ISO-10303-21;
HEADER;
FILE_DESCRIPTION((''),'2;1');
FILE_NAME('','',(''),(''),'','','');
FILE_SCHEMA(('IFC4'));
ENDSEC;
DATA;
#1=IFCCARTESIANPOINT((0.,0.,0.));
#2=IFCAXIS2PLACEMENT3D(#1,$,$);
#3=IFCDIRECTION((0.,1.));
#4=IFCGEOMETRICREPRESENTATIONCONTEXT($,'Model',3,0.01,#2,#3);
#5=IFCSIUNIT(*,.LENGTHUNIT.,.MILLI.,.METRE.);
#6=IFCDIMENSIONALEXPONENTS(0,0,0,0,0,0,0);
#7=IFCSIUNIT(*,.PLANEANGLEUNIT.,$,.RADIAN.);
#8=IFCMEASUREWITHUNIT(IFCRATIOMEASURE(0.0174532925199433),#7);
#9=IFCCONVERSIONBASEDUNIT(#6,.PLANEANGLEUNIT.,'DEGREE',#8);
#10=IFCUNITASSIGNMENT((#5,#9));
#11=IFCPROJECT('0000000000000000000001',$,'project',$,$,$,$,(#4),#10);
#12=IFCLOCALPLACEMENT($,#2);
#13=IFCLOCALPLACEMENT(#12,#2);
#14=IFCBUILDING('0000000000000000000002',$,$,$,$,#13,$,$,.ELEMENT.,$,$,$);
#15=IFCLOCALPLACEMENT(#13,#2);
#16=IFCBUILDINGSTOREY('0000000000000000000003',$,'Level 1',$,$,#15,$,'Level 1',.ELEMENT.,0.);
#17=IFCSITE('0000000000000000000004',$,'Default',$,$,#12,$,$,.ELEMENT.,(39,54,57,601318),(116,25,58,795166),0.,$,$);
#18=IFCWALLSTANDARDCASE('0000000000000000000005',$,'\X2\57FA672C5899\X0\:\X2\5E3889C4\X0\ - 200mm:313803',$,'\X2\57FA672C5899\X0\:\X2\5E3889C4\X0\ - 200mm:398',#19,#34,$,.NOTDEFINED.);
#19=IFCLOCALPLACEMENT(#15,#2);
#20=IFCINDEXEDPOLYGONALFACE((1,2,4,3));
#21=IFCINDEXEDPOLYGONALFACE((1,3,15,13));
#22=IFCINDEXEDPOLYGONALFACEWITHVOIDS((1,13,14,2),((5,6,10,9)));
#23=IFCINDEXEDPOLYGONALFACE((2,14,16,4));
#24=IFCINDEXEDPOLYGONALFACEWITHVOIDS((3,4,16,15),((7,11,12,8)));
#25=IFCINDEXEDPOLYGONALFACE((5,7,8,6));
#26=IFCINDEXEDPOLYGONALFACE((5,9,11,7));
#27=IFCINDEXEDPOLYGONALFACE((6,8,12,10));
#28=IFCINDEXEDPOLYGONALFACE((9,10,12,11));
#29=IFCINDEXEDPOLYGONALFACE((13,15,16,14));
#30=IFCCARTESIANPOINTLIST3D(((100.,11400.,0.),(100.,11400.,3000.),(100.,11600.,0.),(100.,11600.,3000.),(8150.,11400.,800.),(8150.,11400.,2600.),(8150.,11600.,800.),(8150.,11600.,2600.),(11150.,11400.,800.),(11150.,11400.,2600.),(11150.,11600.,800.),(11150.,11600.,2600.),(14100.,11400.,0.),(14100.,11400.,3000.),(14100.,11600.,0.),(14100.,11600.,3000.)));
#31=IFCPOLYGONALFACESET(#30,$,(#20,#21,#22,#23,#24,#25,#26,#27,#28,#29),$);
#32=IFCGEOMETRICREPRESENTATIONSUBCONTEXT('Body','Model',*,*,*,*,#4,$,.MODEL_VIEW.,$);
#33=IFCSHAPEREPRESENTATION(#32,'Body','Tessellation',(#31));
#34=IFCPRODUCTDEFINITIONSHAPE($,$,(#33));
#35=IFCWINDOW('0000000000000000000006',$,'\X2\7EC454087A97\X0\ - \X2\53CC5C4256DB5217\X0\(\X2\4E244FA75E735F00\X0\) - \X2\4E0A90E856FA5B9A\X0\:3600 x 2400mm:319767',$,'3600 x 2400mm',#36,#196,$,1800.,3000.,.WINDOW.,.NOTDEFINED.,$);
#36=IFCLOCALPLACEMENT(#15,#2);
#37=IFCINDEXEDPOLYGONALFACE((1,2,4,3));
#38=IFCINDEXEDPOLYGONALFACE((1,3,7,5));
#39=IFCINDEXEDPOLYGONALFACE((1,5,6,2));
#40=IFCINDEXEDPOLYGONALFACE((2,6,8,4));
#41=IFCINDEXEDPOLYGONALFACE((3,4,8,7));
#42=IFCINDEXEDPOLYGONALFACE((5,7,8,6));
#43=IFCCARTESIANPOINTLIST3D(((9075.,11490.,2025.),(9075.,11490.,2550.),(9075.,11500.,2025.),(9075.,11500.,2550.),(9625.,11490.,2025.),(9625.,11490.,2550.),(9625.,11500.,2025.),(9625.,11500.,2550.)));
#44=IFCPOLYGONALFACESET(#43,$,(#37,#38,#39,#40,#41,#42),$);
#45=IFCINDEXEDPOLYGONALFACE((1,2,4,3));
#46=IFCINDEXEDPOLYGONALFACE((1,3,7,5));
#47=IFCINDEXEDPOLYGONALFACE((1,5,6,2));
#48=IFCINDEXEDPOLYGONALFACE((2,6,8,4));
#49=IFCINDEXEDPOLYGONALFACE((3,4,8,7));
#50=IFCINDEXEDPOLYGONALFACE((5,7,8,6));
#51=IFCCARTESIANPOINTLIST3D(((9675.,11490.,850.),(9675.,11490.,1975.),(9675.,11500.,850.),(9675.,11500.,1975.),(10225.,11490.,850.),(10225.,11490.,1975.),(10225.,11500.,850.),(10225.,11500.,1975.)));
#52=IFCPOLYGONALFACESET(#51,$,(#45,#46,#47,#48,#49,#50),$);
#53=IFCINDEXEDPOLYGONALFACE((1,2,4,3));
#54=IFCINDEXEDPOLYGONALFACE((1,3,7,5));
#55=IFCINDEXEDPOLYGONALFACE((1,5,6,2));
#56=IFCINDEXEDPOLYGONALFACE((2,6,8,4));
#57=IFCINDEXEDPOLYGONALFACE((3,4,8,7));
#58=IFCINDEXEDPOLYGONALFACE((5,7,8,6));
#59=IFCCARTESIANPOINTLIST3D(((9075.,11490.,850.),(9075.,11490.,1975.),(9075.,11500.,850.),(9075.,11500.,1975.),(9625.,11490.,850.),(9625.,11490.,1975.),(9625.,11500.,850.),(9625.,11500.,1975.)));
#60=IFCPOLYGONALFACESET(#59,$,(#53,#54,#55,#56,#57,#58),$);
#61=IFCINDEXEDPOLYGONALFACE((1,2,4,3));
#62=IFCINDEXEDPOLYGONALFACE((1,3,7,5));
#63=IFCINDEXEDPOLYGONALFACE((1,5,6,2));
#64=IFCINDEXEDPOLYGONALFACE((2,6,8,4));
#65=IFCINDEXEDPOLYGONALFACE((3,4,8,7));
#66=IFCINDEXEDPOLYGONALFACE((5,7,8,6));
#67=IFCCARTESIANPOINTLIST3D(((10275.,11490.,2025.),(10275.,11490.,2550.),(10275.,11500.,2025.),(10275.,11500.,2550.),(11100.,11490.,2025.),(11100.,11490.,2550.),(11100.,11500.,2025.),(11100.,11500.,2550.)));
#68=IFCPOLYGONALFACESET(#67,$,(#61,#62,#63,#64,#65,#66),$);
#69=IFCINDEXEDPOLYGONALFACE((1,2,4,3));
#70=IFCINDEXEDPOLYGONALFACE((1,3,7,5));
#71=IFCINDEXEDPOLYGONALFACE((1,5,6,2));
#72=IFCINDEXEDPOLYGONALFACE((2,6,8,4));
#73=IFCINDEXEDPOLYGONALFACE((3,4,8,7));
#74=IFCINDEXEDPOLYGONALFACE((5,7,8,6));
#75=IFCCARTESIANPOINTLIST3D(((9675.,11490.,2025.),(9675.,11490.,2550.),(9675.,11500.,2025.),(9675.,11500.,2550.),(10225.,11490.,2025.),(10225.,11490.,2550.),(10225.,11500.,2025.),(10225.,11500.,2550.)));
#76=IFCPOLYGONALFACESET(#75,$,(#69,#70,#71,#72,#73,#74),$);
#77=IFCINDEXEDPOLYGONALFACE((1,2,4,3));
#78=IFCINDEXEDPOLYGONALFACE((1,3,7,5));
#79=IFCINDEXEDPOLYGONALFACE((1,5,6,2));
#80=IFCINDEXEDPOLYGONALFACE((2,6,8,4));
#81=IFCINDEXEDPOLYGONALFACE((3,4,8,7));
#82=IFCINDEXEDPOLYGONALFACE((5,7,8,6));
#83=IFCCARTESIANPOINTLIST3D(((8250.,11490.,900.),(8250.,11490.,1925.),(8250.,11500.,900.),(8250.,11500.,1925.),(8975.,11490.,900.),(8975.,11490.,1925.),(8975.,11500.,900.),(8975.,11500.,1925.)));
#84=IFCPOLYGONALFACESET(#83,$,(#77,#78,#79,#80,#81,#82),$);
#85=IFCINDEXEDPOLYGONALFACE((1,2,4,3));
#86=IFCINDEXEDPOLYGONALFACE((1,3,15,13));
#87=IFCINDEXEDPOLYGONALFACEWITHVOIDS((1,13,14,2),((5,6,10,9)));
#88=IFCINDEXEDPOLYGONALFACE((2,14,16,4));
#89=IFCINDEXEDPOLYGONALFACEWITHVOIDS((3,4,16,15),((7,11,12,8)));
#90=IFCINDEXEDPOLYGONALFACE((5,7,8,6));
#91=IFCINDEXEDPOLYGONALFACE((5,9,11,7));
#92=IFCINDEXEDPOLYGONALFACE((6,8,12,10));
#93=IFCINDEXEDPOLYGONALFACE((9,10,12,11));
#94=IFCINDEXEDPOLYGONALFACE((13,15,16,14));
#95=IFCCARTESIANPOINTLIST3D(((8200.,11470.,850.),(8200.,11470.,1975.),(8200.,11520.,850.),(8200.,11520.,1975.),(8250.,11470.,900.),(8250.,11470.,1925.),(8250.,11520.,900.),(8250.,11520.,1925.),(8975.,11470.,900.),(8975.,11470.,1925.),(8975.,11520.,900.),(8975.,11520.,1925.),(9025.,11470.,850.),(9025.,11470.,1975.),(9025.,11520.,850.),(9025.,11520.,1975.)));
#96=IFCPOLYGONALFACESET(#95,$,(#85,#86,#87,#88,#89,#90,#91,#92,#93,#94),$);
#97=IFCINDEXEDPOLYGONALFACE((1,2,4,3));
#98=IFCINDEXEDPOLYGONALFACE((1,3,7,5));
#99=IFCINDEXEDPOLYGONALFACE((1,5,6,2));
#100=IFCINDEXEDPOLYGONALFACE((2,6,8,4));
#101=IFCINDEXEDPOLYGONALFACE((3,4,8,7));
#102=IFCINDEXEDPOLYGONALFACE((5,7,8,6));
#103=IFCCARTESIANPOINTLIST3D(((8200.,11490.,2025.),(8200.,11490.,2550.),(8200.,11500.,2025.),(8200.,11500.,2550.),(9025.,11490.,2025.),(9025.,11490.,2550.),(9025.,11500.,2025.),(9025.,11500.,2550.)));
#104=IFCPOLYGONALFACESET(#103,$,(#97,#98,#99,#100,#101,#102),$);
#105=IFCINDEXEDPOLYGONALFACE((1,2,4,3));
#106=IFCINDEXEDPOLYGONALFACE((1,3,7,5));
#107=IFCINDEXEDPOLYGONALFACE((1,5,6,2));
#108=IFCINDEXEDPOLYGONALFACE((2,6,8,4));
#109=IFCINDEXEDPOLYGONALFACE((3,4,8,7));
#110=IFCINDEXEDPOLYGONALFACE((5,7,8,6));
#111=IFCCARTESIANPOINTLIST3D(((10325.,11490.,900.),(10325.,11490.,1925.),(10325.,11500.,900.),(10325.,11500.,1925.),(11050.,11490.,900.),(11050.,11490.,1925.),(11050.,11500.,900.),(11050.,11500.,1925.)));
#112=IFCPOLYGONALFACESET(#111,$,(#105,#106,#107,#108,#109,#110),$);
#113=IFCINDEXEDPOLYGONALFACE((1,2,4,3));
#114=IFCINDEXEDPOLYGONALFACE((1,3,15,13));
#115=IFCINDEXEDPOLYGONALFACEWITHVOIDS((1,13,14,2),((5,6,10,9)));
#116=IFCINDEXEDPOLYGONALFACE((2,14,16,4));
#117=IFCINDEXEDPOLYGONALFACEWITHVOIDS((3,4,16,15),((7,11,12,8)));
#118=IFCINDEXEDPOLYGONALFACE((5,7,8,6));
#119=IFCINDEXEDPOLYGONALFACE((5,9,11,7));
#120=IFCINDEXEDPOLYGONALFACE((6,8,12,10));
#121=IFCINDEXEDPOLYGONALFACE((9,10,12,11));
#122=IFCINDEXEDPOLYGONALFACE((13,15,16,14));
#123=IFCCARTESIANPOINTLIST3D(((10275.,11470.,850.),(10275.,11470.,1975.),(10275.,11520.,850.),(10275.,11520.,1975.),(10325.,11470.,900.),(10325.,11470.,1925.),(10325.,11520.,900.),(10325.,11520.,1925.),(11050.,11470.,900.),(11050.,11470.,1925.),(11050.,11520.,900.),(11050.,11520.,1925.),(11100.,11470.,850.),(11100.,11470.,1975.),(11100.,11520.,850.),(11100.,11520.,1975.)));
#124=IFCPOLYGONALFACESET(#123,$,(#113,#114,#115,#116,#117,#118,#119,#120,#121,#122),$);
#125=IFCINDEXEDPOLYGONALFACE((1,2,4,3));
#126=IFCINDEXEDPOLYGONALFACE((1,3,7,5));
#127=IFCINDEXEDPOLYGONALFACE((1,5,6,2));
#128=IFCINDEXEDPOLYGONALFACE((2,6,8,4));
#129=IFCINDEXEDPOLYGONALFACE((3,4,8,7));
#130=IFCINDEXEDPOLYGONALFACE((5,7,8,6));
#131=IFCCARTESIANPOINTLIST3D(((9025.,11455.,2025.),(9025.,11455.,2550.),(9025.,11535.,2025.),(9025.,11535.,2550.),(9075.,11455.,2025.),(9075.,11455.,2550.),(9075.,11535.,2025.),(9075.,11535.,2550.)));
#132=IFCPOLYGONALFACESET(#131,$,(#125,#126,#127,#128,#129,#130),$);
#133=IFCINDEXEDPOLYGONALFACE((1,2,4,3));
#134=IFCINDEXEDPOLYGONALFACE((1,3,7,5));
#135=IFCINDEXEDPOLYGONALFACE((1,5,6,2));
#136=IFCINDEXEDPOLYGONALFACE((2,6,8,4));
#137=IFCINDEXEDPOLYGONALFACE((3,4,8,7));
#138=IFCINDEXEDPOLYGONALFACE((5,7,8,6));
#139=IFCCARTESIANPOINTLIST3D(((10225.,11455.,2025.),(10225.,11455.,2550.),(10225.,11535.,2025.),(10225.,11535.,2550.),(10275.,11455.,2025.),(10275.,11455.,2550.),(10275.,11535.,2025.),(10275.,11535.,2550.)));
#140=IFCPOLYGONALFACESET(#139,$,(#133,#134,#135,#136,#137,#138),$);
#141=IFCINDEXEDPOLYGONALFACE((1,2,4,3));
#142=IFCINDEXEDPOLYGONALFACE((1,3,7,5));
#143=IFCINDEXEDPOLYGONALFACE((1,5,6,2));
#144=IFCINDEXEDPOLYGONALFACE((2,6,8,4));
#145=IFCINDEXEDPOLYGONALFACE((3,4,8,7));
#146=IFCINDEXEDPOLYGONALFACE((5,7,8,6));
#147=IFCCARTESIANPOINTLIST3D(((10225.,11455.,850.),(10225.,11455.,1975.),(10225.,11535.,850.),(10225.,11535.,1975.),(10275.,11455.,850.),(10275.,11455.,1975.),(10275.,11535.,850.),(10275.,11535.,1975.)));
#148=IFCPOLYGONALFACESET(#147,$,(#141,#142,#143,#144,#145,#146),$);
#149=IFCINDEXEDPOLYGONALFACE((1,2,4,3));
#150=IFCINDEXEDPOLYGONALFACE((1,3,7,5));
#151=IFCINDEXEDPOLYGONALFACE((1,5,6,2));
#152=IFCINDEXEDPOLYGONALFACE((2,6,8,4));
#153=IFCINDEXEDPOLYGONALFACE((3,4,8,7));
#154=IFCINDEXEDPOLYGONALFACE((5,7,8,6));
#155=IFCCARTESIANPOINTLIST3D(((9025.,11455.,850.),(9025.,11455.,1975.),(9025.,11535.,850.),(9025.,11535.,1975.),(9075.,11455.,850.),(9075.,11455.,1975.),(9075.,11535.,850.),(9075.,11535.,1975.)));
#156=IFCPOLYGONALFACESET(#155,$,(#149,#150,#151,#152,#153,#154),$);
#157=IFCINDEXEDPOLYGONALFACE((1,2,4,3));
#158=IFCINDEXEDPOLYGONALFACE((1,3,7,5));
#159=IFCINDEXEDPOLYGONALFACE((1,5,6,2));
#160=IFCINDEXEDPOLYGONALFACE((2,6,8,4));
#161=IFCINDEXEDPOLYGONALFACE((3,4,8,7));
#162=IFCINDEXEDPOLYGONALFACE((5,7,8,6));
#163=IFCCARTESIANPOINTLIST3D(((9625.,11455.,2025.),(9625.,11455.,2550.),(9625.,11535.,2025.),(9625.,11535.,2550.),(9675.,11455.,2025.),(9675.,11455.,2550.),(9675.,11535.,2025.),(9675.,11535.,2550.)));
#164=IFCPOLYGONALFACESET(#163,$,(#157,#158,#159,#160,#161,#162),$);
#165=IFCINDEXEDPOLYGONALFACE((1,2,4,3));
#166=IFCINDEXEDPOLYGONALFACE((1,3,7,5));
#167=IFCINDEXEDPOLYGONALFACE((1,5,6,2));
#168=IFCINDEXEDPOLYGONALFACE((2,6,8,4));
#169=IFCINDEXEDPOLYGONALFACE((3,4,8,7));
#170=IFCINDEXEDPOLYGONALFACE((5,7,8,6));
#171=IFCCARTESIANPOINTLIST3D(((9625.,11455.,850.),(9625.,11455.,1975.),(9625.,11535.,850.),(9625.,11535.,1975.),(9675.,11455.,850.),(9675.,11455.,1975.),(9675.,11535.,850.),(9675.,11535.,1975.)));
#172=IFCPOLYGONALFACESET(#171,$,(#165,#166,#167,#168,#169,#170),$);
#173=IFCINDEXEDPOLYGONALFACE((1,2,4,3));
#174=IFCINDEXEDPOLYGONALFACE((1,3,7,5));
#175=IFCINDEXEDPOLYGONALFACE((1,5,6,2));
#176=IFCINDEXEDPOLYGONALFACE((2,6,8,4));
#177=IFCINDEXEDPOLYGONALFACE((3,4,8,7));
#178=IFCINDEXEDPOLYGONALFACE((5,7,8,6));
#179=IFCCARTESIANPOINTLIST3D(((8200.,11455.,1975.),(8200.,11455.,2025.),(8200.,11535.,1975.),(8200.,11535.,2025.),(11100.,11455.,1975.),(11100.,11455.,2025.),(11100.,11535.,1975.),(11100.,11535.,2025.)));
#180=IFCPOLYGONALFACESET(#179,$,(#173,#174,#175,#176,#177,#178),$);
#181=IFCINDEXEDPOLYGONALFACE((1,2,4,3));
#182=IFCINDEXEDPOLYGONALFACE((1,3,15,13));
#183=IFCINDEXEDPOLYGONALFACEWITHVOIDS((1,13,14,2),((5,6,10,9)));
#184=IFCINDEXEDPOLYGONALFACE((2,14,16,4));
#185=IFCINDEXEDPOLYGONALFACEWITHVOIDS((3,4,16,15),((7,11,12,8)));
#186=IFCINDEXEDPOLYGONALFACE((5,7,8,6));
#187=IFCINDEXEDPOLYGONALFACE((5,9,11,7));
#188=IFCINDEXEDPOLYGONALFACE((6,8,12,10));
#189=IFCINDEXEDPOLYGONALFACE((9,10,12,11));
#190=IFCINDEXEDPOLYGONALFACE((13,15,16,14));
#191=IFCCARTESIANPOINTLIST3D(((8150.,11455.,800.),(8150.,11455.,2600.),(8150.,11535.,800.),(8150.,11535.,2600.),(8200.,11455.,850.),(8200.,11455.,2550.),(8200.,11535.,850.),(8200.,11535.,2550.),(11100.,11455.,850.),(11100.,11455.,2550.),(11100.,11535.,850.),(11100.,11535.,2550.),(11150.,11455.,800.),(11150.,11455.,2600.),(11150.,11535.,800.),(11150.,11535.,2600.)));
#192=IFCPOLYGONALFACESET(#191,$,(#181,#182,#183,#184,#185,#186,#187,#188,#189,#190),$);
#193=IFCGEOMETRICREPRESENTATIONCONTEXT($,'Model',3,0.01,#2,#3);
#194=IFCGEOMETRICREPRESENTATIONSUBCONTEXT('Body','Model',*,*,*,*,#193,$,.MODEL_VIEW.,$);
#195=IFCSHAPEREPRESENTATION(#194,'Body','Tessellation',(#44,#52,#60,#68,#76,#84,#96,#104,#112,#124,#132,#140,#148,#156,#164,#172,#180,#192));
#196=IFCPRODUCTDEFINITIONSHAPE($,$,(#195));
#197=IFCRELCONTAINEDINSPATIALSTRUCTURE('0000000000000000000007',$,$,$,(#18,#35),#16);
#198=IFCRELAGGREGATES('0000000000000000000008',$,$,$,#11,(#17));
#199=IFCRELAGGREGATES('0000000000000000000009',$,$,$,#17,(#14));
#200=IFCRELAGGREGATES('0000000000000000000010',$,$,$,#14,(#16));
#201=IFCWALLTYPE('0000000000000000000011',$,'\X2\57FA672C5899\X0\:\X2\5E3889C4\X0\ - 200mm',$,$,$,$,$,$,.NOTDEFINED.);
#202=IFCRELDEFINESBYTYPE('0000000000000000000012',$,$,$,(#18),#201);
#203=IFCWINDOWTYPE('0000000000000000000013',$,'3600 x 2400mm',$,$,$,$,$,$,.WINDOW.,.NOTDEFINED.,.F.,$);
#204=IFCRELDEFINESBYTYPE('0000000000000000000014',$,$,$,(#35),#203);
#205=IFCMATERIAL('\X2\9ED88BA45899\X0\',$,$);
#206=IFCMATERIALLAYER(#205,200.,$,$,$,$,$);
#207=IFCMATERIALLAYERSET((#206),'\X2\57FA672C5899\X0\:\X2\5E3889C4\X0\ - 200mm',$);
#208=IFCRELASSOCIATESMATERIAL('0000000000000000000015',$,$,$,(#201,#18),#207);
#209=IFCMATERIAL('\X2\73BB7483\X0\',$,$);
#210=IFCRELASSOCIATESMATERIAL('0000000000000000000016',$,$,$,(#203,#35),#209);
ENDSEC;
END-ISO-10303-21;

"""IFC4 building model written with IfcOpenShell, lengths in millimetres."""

from ifc_helpers import new_model, entity, si_unit, converted_unit, direction, frame, frame_2d, origin, origin_2d_with_axis, place, context, subcontext, project, spatial, polyline, rectangle, outline, extrude, source, transform, mapped, material, layer, layer_set, layer_usage, type_object, type_shapes, element, fill, save


model = new_model("IFC4")

# Units and contexts
model_context_1 = context("Model", 3, precision=0.01, world=origin(), true_north=direction((0.0, 1.0)))
model_context_2 = context("Model", 3, precision=0.01, world=origin(), true_north=direction((0.0, 1.0)))
body_context_1 = subcontext(model_context_1, "Body", "Model", "MODEL_VIEW")
body_context_2 = subcontext(model_context_2, "Body", "Model", "MODEL_VIEW")
ifc_project = project(units=[si_unit("LENGTHUNIT", "METRE", prefix="MILLI"), converted_unit("PLANEANGLEUNIT", "DEGREE", entity("IfcRatioMeasure", 0.0174532925199433), si_unit("PLANEANGLEUNIT", "RADIAN"), dimensions=[0, 0, 0, 0, 0, 0, 0])], contexts=[model_context_1])

# Site, building, storey
site_placement = place(None, origin())
site = spatial("IfcSite", under=ifc_project, at=site_placement, Name="Default", CompositionType="ELEMENT", RefLatitude=(39, 54, 57, 601318), RefLongitude=(116, 25, 58, 795166), RefElevation=0.0)
building_placement = place(site_placement, origin())
building = spatial("IfcBuilding", under=site, at=building_placement, CompositionType="ELEMENT")
storey_placement = place(building_placement, origin())
storey = spatial("IfcBuildingStorey", under=building, at=storey_placement, Name="Level 1", LongName="Level 1", CompositionType="ELEMENT", Elevation=0.0)

# Shared definitions
ifc_material_1 = material(Name="默认墙")
ifc_layer_1 = layer(ifc_material_1, 200.0)
ifc_layer_set_1 = layer_set([ifc_layer_1], Name="基本墙:常规 - 200mm")
wall_type_1 = type_object("IfcWallType", Name="基本墙:常规 - 200mm", PredefinedType="NOTDEFINED", material=ifc_layer_set_1)
placement_1 = place(None, origin())
placement_2 = place(placement_1, origin())
placement_3 = place(placement_2, origin())
ifc_material_2 = material(Name="玻璃")

# Wall, opening, window
ifc_layer_usage_1 = layer_usage(ifc_layer_set_1, "AXIS2", "NEGATIVE", 100.0)
wall_1_placement = place(storey_placement, frame((100.0, 11500.0, 0.0)))
wall_1 = element("IfcWallStandardCase", 1, at=wall_1_placement, inside=storey, type_object=wall_type_1, material=ifc_layer_usage_1, Name="基本墙:常规 - 200mm:313803", ObjectType="基本墙:常规 - 200mm:398", PredefinedType="NOTDEFINED", context=body_context_1, shape_type="SweptSolid", body=[
    extrude(rectangle(XDim=14000.0, YDim=200.0, at=frame_2d((7000.0, 0.0), x_axis=(-1.0, 0.0))), origin(), (0.0, 0.0, 1.0), 3000.0),
])
placement_4 = place(placement_3, frame((100.0, 11500.0, 0.0)))
opening_1_placement = place(placement_4, frame((8050.0, -100.0, 800.0)))
opening_1 = element("IfcOpeningElement", 2, at=opening_1_placement, cuts=wall_1, ObjectType="Opening", PredefinedType="OPENING", context=body_context_2, shape_type="SweptSolid", body=[
    extrude(rectangle(XDim=1800.0, YDim=3000.0, at=frame_2d((900.0, 1500.0), x_axis=(1.0, 0.0))), frame((0.0, 0.0, 0.0), z_axis=(0.0, 1.0, 0.0), x_axis=(0.0, 0.0, 1.0)), (0.0, 0.0, 1.0), 200.0),
])
window_type_1 = type_object("IfcWindowType", Name="3600 x 2400mm", ParameterTakesPrecedence=False, PartitioningType="NOTDEFINED", PredefinedType="WINDOW", material=ifc_material_2)
shared_shape_1 = source(origin(), body_context_2, "Body", "SweptSolid", [
    extrude(rectangle(XDim=10.0, YDim=550.0, at=origin_2d_with_axis()), frame((1200.0, 95.0, 1225.0), z_axis=(0.0, 0.0, 1.0), x_axis=(0.0, 1.0, 0.0)), (0.0, 0.0, 1.0), 525.0),
    extrude(rectangle(XDim=10.0, YDim=550.0, at=origin_2d_with_axis()), frame((1800.0, 95.0, 50.0), z_axis=(0.0, 0.0, 1.0), x_axis=(0.0, 1.0, 0.0)), (0.0, 0.0, 1.0), 1125.0),
    extrude(rectangle(XDim=10.0, YDim=550.0, at=origin_2d_with_axis()), frame((1200.0, 95.0, 50.0), z_axis=(0.0, 0.0, 1.0), x_axis=(0.0, 1.0, 0.0)), (0.0, 0.0, 1.0), 1125.0),
    extrude(rectangle(XDim=10.0, YDim=825.0, at=origin_2d_with_axis()), frame((2537.5, 95.0, 1225.0), z_axis=(0.0, 0.0, 1.0), x_axis=(0.0, 1.0, 0.0)), (0.0, 0.0, 1.0), 525.0),
    extrude(rectangle(XDim=10.0, YDim=550.0, at=origin_2d_with_axis()), frame((1800.0, 95.0, 1225.0), z_axis=(0.0, 0.0, 1.0), x_axis=(0.0, 1.0, 0.0)), (0.0, 0.0, 1.0), 525.0),
    extrude(rectangle(XDim=10.0, YDim=725.0, at=origin_2d_with_axis()), frame((462.5, 95.0, 100.0), z_axis=(0.0, 0.0, 1.0), x_axis=(0.0, 1.0, 0.0)), (0.0, 0.0, 1.0), 1025.0),
    extrude(outline(polyline([(-562.5, -412.5), (562.5, -412.5), (562.5, 412.5), (-562.5, 412.5), (-562.5, -412.5)]), holes=[polyline([(512.5, -362.5), (-512.5, -362.5), (-512.5, 362.5), (512.5, 362.5), (512.5, -362.5)])]), frame((462.5, 70.0, 612.5), z_axis=(0.0, 1.0, 0.0), x_axis=(0.0, 0.0, -1.0)), (0.0, 0.0, 1.0), 50.0),
    extrude(rectangle(XDim=10.0, YDim=825.0, at=origin_2d_with_axis()), frame((462.5, 95.0, 1225.0), z_axis=(0.0, 0.0, 1.0), x_axis=(0.0, 1.0, 0.0)), (0.0, 0.0, 1.0), 525.0),
    extrude(rectangle(XDim=10.0, YDim=725.0, at=origin_2d_with_axis()), frame((2537.5, 95.0, 100.0), z_axis=(0.0, 0.0, 1.0), x_axis=(0.0, 1.0, 0.0)), (0.0, 0.0, 1.0), 1025.0),
    extrude(outline(polyline([(-562.5, -412.5), (562.5, -412.5), (562.5, 412.5), (-562.5, 412.5), (-562.5, -412.5)]), holes=[polyline([(512.5, -362.5), (-512.5, -362.5), (-512.5, 362.5), (512.5, 362.5), (512.5, -362.5)])]), frame((2537.5, 70.0, 612.5), z_axis=(0.0, 1.0, 0.0), x_axis=(0.0, 0.0, -1.0)), (0.0, 0.0, 1.0), 50.0),
    extrude(rectangle(XDim=80.0, YDim=50.0, at=origin_2d_with_axis()), frame((900.0, 95.0, 1225.0), z_axis=(0.0, 0.0, 1.0), x_axis=(0.0, -1.0, 0.0)), (0.0, 0.0, 1.0), 525.0),
    extrude(rectangle(XDim=80.0, YDim=50.0, at=origin_2d_with_axis()), frame((2100.0, 95.0, 1225.0), z_axis=(0.0, 0.0, 1.0), x_axis=(0.0, -1.0, 0.0)), (0.0, 0.0, 1.0), 525.0),
    extrude(rectangle(XDim=80.0, YDim=50.0, at=origin_2d_with_axis()), frame((2100.0, 95.0, 50.0), z_axis=(0.0, 0.0, 1.0), x_axis=(0.0, -1.0, 0.0)), (0.0, 0.0, 1.0), 1125.0),
    extrude(rectangle(XDim=80.0, YDim=50.0, at=origin_2d_with_axis()), frame((900.0, 95.0, 50.0), z_axis=(0.0, 0.0, 1.0), x_axis=(0.0, -1.0, 0.0)), (0.0, 0.0, 1.0), 1125.0),
    extrude(rectangle(XDim=80.0, YDim=50.0, at=origin_2d_with_axis()), frame((1500.0, 95.0, 1225.0), z_axis=(0.0, 0.0, 1.0), x_axis=(0.0, -1.0, 0.0)), (0.0, 0.0, 1.0), 525.0),
    extrude(rectangle(XDim=80.0, YDim=50.0, at=origin_2d_with_axis()), frame((1500.0, 95.0, 50.0), z_axis=(0.0, 0.0, 1.0), x_axis=(0.0, -1.0, 0.0)), (0.0, 0.0, 1.0), 1125.0),
    extrude(rectangle(XDim=80.0, YDim=2900.0, at=origin_2d_with_axis()), frame((1500.0, 95.0, 1175.0), z_axis=(0.0, 0.0, 1.0), x_axis=(0.0, -1.0, 0.0)), (0.0, 0.0, 1.0), 50.0),
    extrude(outline(polyline([(-1500.0, -900.0), (1500.0, -900.0), (1500.0, 900.0), (-1500.0, 900.0), (-1500.0, -900.0)]), holes=[polyline([(1450.0, -850.0), (-1450.0, -850.0), (-1450.0, 850.0), (1450.0, 850.0), (1450.0, -850.0)])]), frame((1500.0, 55.0, 900.0), z_axis=(0.0, 1.0, 0.0), x_axis=(1.0, 0.0, 0.0)), (0.0, 0.0, 1.0), 80.0),
])
type_shapes(window_type_1, [shared_shape_1])
window_1_placement = place(opening_1_placement, origin())
window_1 = element("IfcWindow", 3, at=window_1_placement, inside=storey, type_object=window_type_1, material=ifc_material_2, Name="组合窗 - 双层四列(两侧平开) - 上部固定:3600 x 2400mm:319767", ObjectType="3600 x 2400mm", OverallHeight=1800.0, OverallWidth=3000.0, PartitioningType="NOTDEFINED", PredefinedType="WINDOW", context=body_context_2, shape_type="MappedRepresentation", body=[
    mapped(shared_shape_1, transform((0.0, 0.0, 0.0), scale=1.0)),
])
fill(opening_1, window_1)

save(model, "model.ifc")
